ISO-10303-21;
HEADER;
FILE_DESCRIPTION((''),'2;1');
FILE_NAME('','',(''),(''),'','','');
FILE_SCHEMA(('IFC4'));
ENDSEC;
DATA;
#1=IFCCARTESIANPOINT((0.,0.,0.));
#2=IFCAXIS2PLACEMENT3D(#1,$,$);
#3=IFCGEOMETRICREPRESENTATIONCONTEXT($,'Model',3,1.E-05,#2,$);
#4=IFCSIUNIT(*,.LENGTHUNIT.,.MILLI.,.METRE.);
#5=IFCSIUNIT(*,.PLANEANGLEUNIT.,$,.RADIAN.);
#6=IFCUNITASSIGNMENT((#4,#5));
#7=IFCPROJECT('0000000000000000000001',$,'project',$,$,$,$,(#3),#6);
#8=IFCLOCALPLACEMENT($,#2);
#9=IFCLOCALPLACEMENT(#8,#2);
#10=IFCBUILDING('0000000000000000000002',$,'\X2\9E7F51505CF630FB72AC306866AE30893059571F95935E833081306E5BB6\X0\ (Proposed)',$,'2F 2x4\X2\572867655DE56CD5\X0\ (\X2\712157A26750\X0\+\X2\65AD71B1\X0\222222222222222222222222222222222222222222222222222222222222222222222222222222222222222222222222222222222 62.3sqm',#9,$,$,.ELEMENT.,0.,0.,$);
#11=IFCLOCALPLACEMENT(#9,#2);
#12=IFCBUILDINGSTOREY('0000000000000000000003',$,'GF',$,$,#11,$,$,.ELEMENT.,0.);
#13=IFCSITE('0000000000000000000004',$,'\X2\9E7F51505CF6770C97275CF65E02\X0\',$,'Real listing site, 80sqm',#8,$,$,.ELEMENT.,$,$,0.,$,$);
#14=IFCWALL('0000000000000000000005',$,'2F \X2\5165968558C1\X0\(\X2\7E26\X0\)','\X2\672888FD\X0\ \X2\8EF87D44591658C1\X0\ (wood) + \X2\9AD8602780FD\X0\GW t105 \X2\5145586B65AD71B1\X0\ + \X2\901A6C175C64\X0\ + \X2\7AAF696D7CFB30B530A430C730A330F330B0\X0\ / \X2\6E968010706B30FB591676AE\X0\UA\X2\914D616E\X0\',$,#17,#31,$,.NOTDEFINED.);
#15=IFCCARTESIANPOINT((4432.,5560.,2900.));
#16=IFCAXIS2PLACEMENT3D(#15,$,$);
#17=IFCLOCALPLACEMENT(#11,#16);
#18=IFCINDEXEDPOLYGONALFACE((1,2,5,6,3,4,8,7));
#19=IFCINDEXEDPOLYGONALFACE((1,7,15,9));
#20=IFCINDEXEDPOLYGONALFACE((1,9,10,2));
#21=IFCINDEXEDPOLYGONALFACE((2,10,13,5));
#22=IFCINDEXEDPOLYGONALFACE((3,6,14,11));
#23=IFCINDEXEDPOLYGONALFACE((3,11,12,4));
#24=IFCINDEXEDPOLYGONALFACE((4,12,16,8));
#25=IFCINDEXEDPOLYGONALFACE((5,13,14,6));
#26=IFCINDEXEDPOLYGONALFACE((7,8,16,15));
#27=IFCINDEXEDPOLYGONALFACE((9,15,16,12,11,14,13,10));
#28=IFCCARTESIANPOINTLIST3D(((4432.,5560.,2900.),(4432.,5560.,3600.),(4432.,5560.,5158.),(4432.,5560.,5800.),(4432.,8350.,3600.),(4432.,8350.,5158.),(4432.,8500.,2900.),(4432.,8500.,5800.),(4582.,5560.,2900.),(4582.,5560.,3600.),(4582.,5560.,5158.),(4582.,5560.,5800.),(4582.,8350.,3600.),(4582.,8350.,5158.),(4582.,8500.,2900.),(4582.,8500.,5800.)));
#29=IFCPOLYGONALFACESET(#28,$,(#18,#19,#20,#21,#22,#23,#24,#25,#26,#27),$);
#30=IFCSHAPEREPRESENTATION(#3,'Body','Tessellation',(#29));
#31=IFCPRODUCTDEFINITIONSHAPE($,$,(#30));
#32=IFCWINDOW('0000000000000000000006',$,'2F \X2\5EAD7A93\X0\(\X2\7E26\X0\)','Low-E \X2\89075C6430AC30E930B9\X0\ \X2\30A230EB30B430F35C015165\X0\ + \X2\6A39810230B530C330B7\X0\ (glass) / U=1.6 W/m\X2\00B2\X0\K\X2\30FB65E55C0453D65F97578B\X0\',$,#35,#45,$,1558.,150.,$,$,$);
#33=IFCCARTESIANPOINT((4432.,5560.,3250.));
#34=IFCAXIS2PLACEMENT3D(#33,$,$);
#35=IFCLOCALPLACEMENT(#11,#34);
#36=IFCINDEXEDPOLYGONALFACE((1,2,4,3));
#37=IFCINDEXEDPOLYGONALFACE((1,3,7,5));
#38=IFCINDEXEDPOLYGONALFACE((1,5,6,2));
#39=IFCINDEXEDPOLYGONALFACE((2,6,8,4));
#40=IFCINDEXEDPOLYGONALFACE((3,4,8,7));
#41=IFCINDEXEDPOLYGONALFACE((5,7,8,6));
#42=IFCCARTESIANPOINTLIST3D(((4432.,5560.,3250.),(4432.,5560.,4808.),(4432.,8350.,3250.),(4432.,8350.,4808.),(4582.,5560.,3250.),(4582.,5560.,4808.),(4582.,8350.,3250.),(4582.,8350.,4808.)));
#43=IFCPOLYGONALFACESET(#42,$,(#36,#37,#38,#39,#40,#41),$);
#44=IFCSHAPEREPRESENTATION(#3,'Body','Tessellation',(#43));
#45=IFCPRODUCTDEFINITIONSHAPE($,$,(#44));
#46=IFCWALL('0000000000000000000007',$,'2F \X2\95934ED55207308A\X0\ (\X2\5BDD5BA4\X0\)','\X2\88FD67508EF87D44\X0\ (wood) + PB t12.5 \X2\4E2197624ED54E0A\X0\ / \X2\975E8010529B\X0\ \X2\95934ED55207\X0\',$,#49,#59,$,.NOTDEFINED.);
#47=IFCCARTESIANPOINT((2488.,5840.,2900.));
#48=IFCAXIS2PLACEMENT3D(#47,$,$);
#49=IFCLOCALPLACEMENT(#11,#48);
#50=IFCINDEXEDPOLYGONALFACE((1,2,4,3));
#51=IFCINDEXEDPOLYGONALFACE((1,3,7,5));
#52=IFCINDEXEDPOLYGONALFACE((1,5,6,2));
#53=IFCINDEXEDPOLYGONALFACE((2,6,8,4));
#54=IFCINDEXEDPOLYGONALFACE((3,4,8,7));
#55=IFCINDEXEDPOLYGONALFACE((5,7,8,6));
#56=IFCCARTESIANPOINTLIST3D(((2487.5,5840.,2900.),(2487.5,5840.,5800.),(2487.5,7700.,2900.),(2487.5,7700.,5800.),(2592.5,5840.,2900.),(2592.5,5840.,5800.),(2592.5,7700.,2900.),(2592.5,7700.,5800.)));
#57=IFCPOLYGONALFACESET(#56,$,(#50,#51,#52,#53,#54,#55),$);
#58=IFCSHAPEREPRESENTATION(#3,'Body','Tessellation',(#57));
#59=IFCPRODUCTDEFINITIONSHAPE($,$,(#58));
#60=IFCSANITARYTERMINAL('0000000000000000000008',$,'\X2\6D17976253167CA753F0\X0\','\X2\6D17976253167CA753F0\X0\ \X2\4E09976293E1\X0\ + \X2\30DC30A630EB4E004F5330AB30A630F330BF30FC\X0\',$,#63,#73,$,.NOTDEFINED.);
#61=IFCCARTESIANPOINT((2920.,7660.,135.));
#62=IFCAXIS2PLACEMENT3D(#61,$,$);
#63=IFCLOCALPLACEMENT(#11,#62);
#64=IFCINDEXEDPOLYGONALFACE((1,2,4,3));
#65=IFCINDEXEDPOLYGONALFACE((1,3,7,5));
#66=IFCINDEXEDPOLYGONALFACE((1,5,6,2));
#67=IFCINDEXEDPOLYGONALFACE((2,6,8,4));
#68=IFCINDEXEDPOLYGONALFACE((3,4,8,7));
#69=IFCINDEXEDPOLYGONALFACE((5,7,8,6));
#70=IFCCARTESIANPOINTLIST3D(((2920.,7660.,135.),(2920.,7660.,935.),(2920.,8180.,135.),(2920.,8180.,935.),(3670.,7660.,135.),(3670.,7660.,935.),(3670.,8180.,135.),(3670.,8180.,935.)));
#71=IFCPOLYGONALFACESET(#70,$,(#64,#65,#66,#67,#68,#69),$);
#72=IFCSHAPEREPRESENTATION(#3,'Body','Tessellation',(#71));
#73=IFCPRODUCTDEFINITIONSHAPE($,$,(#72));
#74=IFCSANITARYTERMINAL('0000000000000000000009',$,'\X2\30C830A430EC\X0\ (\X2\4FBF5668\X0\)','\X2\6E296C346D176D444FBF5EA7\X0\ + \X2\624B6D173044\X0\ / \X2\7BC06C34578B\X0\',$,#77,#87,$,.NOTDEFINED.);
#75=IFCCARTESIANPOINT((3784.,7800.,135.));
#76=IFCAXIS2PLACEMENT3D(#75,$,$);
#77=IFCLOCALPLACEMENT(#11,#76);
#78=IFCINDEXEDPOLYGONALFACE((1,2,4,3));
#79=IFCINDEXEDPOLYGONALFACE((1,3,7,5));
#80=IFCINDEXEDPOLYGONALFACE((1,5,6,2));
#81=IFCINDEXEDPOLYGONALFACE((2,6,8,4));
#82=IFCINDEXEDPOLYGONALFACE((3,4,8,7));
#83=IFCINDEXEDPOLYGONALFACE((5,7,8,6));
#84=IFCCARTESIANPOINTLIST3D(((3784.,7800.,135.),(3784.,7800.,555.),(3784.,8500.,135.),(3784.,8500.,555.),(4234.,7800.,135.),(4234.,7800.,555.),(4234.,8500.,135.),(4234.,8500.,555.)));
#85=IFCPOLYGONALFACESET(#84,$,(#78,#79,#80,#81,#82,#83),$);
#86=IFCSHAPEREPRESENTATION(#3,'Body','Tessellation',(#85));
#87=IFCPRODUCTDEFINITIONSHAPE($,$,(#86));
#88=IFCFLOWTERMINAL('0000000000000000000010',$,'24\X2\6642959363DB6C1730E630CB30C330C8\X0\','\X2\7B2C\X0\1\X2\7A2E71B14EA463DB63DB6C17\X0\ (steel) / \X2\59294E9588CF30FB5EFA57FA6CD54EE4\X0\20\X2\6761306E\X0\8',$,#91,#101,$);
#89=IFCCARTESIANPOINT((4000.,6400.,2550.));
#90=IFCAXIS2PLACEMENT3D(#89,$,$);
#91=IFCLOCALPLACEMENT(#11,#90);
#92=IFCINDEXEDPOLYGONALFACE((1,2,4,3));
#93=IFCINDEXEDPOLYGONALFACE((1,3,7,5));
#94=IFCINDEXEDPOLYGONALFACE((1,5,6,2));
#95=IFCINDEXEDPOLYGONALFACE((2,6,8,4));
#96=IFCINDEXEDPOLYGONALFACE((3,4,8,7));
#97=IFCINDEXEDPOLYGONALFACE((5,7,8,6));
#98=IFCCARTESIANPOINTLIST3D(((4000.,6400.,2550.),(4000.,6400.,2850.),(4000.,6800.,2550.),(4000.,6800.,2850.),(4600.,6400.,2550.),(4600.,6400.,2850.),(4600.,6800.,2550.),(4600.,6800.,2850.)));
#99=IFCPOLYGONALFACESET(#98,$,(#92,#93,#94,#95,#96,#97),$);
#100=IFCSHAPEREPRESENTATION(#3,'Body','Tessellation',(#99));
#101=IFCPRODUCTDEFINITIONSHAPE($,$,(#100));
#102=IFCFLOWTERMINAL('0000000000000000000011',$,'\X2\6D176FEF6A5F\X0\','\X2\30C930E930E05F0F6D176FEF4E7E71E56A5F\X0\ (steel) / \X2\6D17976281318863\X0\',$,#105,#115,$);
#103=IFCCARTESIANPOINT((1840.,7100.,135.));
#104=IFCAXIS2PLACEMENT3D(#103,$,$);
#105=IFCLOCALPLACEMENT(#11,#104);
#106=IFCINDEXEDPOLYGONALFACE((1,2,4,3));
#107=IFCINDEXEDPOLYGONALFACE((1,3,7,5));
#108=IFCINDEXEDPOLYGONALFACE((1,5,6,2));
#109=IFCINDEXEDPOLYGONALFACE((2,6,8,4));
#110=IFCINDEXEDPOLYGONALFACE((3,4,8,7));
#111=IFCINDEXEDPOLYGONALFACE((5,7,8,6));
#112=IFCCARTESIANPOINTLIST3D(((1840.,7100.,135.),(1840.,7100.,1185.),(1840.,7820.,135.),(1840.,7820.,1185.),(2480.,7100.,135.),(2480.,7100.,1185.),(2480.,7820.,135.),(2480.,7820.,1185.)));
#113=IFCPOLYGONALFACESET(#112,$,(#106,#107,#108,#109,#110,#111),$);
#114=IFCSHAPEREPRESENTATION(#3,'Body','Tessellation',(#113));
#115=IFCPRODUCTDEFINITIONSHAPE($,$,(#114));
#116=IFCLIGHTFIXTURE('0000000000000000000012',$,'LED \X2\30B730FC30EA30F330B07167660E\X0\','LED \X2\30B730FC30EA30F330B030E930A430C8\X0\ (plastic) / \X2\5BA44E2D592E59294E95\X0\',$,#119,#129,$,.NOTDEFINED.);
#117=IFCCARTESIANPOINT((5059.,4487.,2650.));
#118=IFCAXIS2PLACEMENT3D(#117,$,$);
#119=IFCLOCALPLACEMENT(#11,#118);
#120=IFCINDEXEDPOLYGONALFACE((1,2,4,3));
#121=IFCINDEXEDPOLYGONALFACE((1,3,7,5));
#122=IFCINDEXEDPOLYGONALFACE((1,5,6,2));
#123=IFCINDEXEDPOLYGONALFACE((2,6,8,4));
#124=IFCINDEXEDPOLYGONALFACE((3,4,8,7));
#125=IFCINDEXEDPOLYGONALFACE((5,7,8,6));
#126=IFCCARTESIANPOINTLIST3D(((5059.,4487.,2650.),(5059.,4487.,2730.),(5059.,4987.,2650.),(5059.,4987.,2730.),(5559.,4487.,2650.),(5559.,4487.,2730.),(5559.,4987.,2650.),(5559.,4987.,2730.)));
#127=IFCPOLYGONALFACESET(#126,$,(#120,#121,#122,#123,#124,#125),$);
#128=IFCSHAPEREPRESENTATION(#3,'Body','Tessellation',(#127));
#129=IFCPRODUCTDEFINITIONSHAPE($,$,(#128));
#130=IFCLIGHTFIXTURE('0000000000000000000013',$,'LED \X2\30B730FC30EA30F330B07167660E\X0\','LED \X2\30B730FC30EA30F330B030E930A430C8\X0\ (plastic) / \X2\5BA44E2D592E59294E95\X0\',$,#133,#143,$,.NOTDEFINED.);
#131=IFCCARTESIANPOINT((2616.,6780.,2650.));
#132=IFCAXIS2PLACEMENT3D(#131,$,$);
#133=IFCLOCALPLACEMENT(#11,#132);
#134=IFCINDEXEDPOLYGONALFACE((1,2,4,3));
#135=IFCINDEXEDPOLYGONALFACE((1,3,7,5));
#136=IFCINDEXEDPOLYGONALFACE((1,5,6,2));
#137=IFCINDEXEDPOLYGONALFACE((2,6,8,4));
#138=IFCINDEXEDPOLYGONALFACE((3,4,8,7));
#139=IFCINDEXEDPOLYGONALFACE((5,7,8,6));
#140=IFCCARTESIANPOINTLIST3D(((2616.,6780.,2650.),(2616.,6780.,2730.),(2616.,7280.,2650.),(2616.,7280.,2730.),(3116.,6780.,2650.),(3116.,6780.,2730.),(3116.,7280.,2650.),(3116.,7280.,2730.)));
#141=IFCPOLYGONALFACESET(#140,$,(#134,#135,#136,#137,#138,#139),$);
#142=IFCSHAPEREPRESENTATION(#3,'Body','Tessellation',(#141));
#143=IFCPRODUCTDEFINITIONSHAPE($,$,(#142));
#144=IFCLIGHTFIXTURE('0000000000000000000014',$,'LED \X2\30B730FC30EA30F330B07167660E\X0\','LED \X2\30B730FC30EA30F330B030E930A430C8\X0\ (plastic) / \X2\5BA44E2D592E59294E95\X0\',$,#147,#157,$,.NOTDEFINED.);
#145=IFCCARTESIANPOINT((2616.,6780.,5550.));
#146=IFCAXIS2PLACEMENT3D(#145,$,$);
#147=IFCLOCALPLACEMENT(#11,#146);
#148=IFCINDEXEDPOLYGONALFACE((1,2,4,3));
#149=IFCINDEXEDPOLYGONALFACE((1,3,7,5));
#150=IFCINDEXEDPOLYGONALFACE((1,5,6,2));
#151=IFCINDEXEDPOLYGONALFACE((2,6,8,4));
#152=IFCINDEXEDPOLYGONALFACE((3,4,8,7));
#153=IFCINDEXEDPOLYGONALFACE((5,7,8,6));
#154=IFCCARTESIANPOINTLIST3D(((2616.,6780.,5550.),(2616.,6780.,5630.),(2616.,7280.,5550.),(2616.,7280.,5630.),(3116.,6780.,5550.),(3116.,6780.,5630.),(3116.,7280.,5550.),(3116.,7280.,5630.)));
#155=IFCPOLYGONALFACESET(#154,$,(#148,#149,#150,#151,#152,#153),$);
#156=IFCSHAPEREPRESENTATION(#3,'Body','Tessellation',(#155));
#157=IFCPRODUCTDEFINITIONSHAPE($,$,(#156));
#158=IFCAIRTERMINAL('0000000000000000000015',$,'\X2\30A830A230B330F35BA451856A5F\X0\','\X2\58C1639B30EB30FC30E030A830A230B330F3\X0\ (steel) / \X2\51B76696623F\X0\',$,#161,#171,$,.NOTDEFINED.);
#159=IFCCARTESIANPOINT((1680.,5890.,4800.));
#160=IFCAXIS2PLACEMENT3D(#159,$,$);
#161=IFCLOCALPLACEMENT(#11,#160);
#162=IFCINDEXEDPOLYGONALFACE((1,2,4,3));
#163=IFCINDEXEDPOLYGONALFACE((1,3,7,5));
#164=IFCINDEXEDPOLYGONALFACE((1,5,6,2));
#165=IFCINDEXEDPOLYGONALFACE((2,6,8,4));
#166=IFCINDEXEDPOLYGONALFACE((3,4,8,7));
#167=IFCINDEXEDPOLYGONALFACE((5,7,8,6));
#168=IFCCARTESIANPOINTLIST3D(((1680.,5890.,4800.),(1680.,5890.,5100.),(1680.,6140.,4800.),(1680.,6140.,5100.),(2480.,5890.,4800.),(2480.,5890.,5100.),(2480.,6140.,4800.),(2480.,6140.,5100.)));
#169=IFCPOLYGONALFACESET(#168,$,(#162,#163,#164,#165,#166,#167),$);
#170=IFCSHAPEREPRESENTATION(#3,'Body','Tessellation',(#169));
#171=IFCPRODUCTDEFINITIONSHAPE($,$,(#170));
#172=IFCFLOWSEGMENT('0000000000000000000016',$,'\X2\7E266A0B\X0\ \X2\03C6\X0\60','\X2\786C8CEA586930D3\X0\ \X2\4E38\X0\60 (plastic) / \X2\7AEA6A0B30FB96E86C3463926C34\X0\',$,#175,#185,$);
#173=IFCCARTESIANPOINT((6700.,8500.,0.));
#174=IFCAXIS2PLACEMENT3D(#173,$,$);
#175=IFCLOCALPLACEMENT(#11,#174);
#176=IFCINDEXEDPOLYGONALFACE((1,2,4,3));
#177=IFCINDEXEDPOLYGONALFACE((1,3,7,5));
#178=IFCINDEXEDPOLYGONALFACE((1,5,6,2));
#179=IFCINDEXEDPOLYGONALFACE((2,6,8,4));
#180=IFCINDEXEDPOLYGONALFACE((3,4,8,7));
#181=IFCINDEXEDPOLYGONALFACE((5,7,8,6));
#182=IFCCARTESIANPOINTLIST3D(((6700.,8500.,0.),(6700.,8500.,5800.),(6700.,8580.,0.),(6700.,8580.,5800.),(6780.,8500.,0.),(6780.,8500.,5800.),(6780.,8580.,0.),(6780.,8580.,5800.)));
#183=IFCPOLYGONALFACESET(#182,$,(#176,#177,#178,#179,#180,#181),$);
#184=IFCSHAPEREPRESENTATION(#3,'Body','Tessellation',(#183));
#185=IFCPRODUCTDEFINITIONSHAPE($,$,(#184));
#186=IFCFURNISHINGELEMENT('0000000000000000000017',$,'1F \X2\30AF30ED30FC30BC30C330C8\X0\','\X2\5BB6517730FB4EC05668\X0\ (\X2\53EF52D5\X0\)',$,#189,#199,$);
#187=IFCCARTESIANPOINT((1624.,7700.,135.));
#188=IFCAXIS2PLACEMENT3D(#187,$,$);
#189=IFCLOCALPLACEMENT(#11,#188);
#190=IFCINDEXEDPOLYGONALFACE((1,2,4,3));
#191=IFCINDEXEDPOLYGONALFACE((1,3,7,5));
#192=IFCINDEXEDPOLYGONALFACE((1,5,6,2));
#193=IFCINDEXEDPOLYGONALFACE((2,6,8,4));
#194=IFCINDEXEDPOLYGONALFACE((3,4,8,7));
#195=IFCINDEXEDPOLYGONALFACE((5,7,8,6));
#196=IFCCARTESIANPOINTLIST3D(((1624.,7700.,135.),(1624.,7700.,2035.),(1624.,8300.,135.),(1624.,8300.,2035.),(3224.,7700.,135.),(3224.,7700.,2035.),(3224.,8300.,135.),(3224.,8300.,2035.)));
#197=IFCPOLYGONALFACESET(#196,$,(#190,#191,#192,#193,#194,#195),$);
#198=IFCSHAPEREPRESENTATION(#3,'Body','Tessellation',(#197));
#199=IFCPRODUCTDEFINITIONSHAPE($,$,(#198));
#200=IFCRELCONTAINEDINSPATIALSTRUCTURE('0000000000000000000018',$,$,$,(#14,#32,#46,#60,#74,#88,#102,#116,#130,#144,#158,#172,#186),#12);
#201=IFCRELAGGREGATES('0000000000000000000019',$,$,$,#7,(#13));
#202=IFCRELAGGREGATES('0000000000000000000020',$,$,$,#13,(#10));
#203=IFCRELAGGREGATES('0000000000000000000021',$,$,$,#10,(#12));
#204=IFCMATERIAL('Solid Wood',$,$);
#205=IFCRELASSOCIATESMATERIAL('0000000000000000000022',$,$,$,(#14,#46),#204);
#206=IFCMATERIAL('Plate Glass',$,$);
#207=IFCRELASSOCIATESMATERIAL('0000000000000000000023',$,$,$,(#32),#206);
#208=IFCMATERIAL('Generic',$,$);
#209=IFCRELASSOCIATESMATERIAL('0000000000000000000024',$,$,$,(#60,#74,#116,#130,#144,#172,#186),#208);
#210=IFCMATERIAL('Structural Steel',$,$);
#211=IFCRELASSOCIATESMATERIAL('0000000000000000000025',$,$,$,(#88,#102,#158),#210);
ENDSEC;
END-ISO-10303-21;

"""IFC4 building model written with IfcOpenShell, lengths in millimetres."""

from ifc_helpers import new_model, si_unit, frame, frame_2d, origin, place, context, project, spatial, rectangle, extrude, material, element, fill, save


model = new_model("IFC4")

# Units and contexts
model_context = context("Model", 3, precision=1e-05, world=origin())
ifc_project = project(units=[si_unit("LENGTHUNIT", "METRE", prefix="MILLI"), si_unit("PLANEANGLEUNIT", "RADIAN")], contexts=[model_context])

# Site, building, storey
site_placement = place(None, origin())
site = spatial("IfcSite", under=ifc_project, at=site_placement, Name="鹿児島県霧島市", ObjectType="Real listing site, 80sqm", CompositionType="ELEMENT", RefElevation=0.0)
building_placement = place(site_placement, origin())
building = spatial("IfcBuilding", under=site, at=building_placement, Name="鹿児島・犬と暮らす土間広めの家 (Proposed)", ObjectType="2F 2x4在来工法 (無垢材+断熱222222222222222222222222222222222222222222222222222222222222222222222222222222222222222222222222222222222 62.3sqm", CompositionType="ELEMENT", ElevationOfRefHeight=0.0, ElevationOfTerrain=0.0)
storey_placement = place(building_placement, origin())
storey = spatial("IfcBuildingStorey", under=building, at=storey_placement, Name="GF", CompositionType="ELEMENT", Elevation=0.0)

# Shared definitions
ifc_material_1 = material(Name="Solid Wood")

# Shared definitions
ifc_material_2 = material(Name="Plate Glass")

# Wall, opening, window
wall_1_placement = place(storey_placement, frame((4432.0, 5560.0, 2900.0)))
wall_1 = element("IfcWall", 1, at=wall_1_placement, inside=storey, material=ifc_material_1, Name="2F 入隅壁(縦)", Description="木製 軸組外壁 (wood) + 高性能GW t105 充填断熱 + 通気層 + 窯業系サイディング / 準耐火・外皮UA配慮", PredefinedType="NOTDEFINED", context=model_context, shape_type="SweptSolid", body=[
    extrude(rectangle(XDim=150.0, YDim=2940.0, at=frame_2d((75.0, 1470.0))), frame((4432.0, 5560.0, 2900.0)), (0.0, 0.0, 1.0), 2900.0),
])
opening_1_placement = place(storey_placement, frame((4432.0, 5560.0, 3250.0)))
opening_1 = element("IfcOpeningElement", 2, at=opening_1_placement, cuts=wall_1, PredefinedType="NOTDEFINED", context=model_context, shape_type="SweptSolid", body=[
    extrude(rectangle(XDim=150.0, YDim=2790.0, at=frame_2d((75.0, 1395.0))), frame((4432.0, 5560.0, 3250.0)), (0.0, 0.0, 1.0), 1558.0),
])
window_1_placement = place(storey_placement, frame((4432.0, 5560.0, 3250.0)))
window_1 = element("IfcWindow", 3, at=window_1_placement, inside=storey, material=ifc_material_2, Name="2F 庭窓(縦)", Description="Low-E 複層ガラス アルゴン封入 + 樹脂サッシ (glass) / U=1.6 W/m²K・日射取得型", OverallHeight=1558.0, OverallWidth=150.0, context=model_context, shape_type="SweptSolid", body=[
    extrude(rectangle(XDim=150.0, YDim=2790.0, at=frame_2d((75.0, 1395.0))), frame((4432.0, 5560.0, 3250.0)), (0.0, 0.0, 1.0), 1558.0),
])
fill(opening_1, window_1)

# Wall
wall_2_placement = place(storey_placement, frame((2488.0, 5840.0, 2900.0)))
element("IfcWall", 4, at=wall_2_placement, inside=storey, material=ifc_material_1, Name="2F 間仕切り (寝室)", Description="製材軸組 (wood) + PB t12.5 両面仕上 / 非耐力 間仕切", PredefinedType="NOTDEFINED", context=model_context, shape_type="SweptSolid", body=[
    extrude(rectangle(XDim=105.0, YDim=1860.0, at=frame_2d((52.0, 930.0))), frame((2488.0, 5840.0, 2900.0)), (0.0, 0.0, 1.0), 2900.0),
])

# Sanitary terminals
ifc_material_3 = material(Name="Generic")
sanitary_terminal_1_placement = place(storey_placement, frame((2920.0, 7660.0, 135.0)))
element("IfcSanitaryTerminal", 5, at=sanitary_terminal_1_placement, inside=storey, material=ifc_material_3, Name="洗面化粧台", Description="洗面化粧台 三面鏡 + ボウル一体カウンター", PredefinedType="NOTDEFINED", context=model_context, shape_type="SweptSolid", body=[
    extrude(rectangle(XDim=750.0, YDim=520.0, at=frame_2d((375.0, 260.0))), frame((2920.0, 7660.0, 135.0)), (0.0, 0.0, 1.0), 800.0),
])
sanitary_terminal_2_placement = place(storey_placement, frame((3784.0, 7800.0, 135.0)))
element("IfcSanitaryTerminal", 6, at=sanitary_terminal_2_placement, inside=storey, material=ifc_material_3, Name="トイレ (便器)", Description="温水洗浄便座 + 手洗い / 節水型", PredefinedType="NOTDEFINED", context=model_context, shape_type="SweptSolid", body=[
    extrude(rectangle(XDim=450.0, YDim=700.0, at=frame_2d((225.0, 350.0))), frame((3784.0, 7800.0, 135.0)), (0.0, 0.0, 1.0), 420.0),
])

# Flow terminals
ifc_material_4 = material(Name="Structural Steel")
flow_terminal_1_placement = place(storey_placement, frame((4000.0, 6400.0, 2550.0)))
element("IfcFlowTerminal", 7, at=flow_terminal_1_placement, inside=storey, material=ifc_material_4, Name="24時間換気ユニット", Description="第1種熱交換換気 (steel) / 天井裏・建基法令20条の8", context=model_context, shape_type="SweptSolid", body=[
    extrude(rectangle(XDim=600.0, YDim=400.0, at=frame_2d((300.0, 200.0))), frame((4000.0, 6400.0, 2550.0)), (0.0, 0.0, 1.0), 300.0),
])
flow_terminal_2_placement = place(storey_placement, frame((1840.0, 7100.0, 135.0)))
element("IfcFlowTerminal", 8, at=flow_terminal_2_placement, inside=storey, material=ifc_material_4, Name="洗濯機", Description="ドラム式洗濯乾燥機 (steel) / 洗面脱衣", context=model_context, shape_type="SweptSolid", body=[
    extrude(rectangle(XDim=640.0, YDim=720.0, at=frame_2d((320.0, 360.0))), frame((1840.0, 7100.0, 135.0)), (0.0, 0.0, 1.0), 1050.0),
])

# Light fixtures
light_fixture_1_placement = place(storey_placement, frame((5059.0, 4487.0, 2650.0)))
element("IfcLightFixture", 9, at=light_fixture_1_placement, inside=storey, material=ifc_material_3, Name="LED シーリング照明", Description="LED シーリングライト (plastic) / 室中央天井", PredefinedType="NOTDEFINED", context=model_context, shape_type="SweptSolid", body=[
    extrude(rectangle(XDim=500.0, YDim=500.0, at=frame_2d((250.0, 250.0))), frame((5059.0, 4487.0, 2650.0)), (0.0, 0.0, 1.0), 80.0),
])
light_fixture_2_placement = place(storey_placement, frame((2616.0, 6780.0, 2650.0)))
element("IfcLightFixture", 10, at=light_fixture_2_placement, inside=storey, material=ifc_material_3, Name="LED シーリング照明", Description="LED シーリングライト (plastic) / 室中央天井", PredefinedType="NOTDEFINED", context=model_context, shape_type="SweptSolid", body=[
    extrude(rectangle(XDim=500.0, YDim=500.0, at=frame_2d((250.0, 250.0))), frame((2616.0, 6780.0, 2650.0)), (0.0, 0.0, 1.0), 80.0),
])
light_fixture_3_placement = place(storey_placement, frame((2616.0, 6780.0, 5550.0)))
element("IfcLightFixture", 11, at=light_fixture_3_placement, inside=storey, material=ifc_material_3, Name="LED シーリング照明", Description="LED シーリングライト (plastic) / 室中央天井", PredefinedType="NOTDEFINED", context=model_context, shape_type="SweptSolid", body=[
    extrude(rectangle(XDim=500.0, YDim=500.0, at=frame_2d((250.0, 250.0))), frame((2616.0, 6780.0, 5550.0)), (0.0, 0.0, 1.0), 80.0),
])

# Air terminal
air_terminal_placement = place(storey_placement, frame((1680.0, 5890.0, 4800.0)))
element("IfcAirTerminal", 12, at=air_terminal_placement, inside=storey, material=ifc_material_4, Name="エアコン室内機", Description="壁掛ルームエアコン (steel) / 冷暖房", PredefinedType="NOTDEFINED", context=model_context, shape_type="SweptSolid", body=[
    extrude(rectangle(XDim=800.0, YDim=250.0, at=frame_2d((400.0, 125.0))), frame((1680.0, 5890.0, 4800.0)), (0.0, 0.0, 1.0), 300.0),
])

# Flow segment
flow_segment_placement = place(storey_placement, frame((6700.0, 8500.0, 0.0)))
element("IfcFlowSegment", 13, at=flow_segment_placement, inside=storey, material=ifc_material_3, Name="縦樋 φ60", Description="硬質塩ビ 丸60 (plastic) / 竪樋・雨水排水", context=model_context, shape_type="SweptSolid", body=[
    extrude(rectangle(XDim=80.0, YDim=80.0, at=frame_2d((40.0, 40.0))), frame((6700.0, 8500.0, 0.0)), (0.0, 0.0, 1.0), 5800.0),
])

# Furnishing element
furnishing_1_placement = place(storey_placement, frame((1624.0, 7700.0, 135.0)))
element("IfcFurnishingElement", 14, at=furnishing_1_placement, inside=storey, material=ifc_material_3, Name="1F クローゼット", Description="家具・什器 (可動)", context=model_context, shape_type="SweptSolid", body=[
    extrude(rectangle(XDim=1600.0, YDim=600.0, at=frame_2d((800.0, 300.0))), frame((1624.0, 7700.0, 135.0)), (0.0, 0.0, 1.0), 1900.0),
])

save(model, "model.ifc")
